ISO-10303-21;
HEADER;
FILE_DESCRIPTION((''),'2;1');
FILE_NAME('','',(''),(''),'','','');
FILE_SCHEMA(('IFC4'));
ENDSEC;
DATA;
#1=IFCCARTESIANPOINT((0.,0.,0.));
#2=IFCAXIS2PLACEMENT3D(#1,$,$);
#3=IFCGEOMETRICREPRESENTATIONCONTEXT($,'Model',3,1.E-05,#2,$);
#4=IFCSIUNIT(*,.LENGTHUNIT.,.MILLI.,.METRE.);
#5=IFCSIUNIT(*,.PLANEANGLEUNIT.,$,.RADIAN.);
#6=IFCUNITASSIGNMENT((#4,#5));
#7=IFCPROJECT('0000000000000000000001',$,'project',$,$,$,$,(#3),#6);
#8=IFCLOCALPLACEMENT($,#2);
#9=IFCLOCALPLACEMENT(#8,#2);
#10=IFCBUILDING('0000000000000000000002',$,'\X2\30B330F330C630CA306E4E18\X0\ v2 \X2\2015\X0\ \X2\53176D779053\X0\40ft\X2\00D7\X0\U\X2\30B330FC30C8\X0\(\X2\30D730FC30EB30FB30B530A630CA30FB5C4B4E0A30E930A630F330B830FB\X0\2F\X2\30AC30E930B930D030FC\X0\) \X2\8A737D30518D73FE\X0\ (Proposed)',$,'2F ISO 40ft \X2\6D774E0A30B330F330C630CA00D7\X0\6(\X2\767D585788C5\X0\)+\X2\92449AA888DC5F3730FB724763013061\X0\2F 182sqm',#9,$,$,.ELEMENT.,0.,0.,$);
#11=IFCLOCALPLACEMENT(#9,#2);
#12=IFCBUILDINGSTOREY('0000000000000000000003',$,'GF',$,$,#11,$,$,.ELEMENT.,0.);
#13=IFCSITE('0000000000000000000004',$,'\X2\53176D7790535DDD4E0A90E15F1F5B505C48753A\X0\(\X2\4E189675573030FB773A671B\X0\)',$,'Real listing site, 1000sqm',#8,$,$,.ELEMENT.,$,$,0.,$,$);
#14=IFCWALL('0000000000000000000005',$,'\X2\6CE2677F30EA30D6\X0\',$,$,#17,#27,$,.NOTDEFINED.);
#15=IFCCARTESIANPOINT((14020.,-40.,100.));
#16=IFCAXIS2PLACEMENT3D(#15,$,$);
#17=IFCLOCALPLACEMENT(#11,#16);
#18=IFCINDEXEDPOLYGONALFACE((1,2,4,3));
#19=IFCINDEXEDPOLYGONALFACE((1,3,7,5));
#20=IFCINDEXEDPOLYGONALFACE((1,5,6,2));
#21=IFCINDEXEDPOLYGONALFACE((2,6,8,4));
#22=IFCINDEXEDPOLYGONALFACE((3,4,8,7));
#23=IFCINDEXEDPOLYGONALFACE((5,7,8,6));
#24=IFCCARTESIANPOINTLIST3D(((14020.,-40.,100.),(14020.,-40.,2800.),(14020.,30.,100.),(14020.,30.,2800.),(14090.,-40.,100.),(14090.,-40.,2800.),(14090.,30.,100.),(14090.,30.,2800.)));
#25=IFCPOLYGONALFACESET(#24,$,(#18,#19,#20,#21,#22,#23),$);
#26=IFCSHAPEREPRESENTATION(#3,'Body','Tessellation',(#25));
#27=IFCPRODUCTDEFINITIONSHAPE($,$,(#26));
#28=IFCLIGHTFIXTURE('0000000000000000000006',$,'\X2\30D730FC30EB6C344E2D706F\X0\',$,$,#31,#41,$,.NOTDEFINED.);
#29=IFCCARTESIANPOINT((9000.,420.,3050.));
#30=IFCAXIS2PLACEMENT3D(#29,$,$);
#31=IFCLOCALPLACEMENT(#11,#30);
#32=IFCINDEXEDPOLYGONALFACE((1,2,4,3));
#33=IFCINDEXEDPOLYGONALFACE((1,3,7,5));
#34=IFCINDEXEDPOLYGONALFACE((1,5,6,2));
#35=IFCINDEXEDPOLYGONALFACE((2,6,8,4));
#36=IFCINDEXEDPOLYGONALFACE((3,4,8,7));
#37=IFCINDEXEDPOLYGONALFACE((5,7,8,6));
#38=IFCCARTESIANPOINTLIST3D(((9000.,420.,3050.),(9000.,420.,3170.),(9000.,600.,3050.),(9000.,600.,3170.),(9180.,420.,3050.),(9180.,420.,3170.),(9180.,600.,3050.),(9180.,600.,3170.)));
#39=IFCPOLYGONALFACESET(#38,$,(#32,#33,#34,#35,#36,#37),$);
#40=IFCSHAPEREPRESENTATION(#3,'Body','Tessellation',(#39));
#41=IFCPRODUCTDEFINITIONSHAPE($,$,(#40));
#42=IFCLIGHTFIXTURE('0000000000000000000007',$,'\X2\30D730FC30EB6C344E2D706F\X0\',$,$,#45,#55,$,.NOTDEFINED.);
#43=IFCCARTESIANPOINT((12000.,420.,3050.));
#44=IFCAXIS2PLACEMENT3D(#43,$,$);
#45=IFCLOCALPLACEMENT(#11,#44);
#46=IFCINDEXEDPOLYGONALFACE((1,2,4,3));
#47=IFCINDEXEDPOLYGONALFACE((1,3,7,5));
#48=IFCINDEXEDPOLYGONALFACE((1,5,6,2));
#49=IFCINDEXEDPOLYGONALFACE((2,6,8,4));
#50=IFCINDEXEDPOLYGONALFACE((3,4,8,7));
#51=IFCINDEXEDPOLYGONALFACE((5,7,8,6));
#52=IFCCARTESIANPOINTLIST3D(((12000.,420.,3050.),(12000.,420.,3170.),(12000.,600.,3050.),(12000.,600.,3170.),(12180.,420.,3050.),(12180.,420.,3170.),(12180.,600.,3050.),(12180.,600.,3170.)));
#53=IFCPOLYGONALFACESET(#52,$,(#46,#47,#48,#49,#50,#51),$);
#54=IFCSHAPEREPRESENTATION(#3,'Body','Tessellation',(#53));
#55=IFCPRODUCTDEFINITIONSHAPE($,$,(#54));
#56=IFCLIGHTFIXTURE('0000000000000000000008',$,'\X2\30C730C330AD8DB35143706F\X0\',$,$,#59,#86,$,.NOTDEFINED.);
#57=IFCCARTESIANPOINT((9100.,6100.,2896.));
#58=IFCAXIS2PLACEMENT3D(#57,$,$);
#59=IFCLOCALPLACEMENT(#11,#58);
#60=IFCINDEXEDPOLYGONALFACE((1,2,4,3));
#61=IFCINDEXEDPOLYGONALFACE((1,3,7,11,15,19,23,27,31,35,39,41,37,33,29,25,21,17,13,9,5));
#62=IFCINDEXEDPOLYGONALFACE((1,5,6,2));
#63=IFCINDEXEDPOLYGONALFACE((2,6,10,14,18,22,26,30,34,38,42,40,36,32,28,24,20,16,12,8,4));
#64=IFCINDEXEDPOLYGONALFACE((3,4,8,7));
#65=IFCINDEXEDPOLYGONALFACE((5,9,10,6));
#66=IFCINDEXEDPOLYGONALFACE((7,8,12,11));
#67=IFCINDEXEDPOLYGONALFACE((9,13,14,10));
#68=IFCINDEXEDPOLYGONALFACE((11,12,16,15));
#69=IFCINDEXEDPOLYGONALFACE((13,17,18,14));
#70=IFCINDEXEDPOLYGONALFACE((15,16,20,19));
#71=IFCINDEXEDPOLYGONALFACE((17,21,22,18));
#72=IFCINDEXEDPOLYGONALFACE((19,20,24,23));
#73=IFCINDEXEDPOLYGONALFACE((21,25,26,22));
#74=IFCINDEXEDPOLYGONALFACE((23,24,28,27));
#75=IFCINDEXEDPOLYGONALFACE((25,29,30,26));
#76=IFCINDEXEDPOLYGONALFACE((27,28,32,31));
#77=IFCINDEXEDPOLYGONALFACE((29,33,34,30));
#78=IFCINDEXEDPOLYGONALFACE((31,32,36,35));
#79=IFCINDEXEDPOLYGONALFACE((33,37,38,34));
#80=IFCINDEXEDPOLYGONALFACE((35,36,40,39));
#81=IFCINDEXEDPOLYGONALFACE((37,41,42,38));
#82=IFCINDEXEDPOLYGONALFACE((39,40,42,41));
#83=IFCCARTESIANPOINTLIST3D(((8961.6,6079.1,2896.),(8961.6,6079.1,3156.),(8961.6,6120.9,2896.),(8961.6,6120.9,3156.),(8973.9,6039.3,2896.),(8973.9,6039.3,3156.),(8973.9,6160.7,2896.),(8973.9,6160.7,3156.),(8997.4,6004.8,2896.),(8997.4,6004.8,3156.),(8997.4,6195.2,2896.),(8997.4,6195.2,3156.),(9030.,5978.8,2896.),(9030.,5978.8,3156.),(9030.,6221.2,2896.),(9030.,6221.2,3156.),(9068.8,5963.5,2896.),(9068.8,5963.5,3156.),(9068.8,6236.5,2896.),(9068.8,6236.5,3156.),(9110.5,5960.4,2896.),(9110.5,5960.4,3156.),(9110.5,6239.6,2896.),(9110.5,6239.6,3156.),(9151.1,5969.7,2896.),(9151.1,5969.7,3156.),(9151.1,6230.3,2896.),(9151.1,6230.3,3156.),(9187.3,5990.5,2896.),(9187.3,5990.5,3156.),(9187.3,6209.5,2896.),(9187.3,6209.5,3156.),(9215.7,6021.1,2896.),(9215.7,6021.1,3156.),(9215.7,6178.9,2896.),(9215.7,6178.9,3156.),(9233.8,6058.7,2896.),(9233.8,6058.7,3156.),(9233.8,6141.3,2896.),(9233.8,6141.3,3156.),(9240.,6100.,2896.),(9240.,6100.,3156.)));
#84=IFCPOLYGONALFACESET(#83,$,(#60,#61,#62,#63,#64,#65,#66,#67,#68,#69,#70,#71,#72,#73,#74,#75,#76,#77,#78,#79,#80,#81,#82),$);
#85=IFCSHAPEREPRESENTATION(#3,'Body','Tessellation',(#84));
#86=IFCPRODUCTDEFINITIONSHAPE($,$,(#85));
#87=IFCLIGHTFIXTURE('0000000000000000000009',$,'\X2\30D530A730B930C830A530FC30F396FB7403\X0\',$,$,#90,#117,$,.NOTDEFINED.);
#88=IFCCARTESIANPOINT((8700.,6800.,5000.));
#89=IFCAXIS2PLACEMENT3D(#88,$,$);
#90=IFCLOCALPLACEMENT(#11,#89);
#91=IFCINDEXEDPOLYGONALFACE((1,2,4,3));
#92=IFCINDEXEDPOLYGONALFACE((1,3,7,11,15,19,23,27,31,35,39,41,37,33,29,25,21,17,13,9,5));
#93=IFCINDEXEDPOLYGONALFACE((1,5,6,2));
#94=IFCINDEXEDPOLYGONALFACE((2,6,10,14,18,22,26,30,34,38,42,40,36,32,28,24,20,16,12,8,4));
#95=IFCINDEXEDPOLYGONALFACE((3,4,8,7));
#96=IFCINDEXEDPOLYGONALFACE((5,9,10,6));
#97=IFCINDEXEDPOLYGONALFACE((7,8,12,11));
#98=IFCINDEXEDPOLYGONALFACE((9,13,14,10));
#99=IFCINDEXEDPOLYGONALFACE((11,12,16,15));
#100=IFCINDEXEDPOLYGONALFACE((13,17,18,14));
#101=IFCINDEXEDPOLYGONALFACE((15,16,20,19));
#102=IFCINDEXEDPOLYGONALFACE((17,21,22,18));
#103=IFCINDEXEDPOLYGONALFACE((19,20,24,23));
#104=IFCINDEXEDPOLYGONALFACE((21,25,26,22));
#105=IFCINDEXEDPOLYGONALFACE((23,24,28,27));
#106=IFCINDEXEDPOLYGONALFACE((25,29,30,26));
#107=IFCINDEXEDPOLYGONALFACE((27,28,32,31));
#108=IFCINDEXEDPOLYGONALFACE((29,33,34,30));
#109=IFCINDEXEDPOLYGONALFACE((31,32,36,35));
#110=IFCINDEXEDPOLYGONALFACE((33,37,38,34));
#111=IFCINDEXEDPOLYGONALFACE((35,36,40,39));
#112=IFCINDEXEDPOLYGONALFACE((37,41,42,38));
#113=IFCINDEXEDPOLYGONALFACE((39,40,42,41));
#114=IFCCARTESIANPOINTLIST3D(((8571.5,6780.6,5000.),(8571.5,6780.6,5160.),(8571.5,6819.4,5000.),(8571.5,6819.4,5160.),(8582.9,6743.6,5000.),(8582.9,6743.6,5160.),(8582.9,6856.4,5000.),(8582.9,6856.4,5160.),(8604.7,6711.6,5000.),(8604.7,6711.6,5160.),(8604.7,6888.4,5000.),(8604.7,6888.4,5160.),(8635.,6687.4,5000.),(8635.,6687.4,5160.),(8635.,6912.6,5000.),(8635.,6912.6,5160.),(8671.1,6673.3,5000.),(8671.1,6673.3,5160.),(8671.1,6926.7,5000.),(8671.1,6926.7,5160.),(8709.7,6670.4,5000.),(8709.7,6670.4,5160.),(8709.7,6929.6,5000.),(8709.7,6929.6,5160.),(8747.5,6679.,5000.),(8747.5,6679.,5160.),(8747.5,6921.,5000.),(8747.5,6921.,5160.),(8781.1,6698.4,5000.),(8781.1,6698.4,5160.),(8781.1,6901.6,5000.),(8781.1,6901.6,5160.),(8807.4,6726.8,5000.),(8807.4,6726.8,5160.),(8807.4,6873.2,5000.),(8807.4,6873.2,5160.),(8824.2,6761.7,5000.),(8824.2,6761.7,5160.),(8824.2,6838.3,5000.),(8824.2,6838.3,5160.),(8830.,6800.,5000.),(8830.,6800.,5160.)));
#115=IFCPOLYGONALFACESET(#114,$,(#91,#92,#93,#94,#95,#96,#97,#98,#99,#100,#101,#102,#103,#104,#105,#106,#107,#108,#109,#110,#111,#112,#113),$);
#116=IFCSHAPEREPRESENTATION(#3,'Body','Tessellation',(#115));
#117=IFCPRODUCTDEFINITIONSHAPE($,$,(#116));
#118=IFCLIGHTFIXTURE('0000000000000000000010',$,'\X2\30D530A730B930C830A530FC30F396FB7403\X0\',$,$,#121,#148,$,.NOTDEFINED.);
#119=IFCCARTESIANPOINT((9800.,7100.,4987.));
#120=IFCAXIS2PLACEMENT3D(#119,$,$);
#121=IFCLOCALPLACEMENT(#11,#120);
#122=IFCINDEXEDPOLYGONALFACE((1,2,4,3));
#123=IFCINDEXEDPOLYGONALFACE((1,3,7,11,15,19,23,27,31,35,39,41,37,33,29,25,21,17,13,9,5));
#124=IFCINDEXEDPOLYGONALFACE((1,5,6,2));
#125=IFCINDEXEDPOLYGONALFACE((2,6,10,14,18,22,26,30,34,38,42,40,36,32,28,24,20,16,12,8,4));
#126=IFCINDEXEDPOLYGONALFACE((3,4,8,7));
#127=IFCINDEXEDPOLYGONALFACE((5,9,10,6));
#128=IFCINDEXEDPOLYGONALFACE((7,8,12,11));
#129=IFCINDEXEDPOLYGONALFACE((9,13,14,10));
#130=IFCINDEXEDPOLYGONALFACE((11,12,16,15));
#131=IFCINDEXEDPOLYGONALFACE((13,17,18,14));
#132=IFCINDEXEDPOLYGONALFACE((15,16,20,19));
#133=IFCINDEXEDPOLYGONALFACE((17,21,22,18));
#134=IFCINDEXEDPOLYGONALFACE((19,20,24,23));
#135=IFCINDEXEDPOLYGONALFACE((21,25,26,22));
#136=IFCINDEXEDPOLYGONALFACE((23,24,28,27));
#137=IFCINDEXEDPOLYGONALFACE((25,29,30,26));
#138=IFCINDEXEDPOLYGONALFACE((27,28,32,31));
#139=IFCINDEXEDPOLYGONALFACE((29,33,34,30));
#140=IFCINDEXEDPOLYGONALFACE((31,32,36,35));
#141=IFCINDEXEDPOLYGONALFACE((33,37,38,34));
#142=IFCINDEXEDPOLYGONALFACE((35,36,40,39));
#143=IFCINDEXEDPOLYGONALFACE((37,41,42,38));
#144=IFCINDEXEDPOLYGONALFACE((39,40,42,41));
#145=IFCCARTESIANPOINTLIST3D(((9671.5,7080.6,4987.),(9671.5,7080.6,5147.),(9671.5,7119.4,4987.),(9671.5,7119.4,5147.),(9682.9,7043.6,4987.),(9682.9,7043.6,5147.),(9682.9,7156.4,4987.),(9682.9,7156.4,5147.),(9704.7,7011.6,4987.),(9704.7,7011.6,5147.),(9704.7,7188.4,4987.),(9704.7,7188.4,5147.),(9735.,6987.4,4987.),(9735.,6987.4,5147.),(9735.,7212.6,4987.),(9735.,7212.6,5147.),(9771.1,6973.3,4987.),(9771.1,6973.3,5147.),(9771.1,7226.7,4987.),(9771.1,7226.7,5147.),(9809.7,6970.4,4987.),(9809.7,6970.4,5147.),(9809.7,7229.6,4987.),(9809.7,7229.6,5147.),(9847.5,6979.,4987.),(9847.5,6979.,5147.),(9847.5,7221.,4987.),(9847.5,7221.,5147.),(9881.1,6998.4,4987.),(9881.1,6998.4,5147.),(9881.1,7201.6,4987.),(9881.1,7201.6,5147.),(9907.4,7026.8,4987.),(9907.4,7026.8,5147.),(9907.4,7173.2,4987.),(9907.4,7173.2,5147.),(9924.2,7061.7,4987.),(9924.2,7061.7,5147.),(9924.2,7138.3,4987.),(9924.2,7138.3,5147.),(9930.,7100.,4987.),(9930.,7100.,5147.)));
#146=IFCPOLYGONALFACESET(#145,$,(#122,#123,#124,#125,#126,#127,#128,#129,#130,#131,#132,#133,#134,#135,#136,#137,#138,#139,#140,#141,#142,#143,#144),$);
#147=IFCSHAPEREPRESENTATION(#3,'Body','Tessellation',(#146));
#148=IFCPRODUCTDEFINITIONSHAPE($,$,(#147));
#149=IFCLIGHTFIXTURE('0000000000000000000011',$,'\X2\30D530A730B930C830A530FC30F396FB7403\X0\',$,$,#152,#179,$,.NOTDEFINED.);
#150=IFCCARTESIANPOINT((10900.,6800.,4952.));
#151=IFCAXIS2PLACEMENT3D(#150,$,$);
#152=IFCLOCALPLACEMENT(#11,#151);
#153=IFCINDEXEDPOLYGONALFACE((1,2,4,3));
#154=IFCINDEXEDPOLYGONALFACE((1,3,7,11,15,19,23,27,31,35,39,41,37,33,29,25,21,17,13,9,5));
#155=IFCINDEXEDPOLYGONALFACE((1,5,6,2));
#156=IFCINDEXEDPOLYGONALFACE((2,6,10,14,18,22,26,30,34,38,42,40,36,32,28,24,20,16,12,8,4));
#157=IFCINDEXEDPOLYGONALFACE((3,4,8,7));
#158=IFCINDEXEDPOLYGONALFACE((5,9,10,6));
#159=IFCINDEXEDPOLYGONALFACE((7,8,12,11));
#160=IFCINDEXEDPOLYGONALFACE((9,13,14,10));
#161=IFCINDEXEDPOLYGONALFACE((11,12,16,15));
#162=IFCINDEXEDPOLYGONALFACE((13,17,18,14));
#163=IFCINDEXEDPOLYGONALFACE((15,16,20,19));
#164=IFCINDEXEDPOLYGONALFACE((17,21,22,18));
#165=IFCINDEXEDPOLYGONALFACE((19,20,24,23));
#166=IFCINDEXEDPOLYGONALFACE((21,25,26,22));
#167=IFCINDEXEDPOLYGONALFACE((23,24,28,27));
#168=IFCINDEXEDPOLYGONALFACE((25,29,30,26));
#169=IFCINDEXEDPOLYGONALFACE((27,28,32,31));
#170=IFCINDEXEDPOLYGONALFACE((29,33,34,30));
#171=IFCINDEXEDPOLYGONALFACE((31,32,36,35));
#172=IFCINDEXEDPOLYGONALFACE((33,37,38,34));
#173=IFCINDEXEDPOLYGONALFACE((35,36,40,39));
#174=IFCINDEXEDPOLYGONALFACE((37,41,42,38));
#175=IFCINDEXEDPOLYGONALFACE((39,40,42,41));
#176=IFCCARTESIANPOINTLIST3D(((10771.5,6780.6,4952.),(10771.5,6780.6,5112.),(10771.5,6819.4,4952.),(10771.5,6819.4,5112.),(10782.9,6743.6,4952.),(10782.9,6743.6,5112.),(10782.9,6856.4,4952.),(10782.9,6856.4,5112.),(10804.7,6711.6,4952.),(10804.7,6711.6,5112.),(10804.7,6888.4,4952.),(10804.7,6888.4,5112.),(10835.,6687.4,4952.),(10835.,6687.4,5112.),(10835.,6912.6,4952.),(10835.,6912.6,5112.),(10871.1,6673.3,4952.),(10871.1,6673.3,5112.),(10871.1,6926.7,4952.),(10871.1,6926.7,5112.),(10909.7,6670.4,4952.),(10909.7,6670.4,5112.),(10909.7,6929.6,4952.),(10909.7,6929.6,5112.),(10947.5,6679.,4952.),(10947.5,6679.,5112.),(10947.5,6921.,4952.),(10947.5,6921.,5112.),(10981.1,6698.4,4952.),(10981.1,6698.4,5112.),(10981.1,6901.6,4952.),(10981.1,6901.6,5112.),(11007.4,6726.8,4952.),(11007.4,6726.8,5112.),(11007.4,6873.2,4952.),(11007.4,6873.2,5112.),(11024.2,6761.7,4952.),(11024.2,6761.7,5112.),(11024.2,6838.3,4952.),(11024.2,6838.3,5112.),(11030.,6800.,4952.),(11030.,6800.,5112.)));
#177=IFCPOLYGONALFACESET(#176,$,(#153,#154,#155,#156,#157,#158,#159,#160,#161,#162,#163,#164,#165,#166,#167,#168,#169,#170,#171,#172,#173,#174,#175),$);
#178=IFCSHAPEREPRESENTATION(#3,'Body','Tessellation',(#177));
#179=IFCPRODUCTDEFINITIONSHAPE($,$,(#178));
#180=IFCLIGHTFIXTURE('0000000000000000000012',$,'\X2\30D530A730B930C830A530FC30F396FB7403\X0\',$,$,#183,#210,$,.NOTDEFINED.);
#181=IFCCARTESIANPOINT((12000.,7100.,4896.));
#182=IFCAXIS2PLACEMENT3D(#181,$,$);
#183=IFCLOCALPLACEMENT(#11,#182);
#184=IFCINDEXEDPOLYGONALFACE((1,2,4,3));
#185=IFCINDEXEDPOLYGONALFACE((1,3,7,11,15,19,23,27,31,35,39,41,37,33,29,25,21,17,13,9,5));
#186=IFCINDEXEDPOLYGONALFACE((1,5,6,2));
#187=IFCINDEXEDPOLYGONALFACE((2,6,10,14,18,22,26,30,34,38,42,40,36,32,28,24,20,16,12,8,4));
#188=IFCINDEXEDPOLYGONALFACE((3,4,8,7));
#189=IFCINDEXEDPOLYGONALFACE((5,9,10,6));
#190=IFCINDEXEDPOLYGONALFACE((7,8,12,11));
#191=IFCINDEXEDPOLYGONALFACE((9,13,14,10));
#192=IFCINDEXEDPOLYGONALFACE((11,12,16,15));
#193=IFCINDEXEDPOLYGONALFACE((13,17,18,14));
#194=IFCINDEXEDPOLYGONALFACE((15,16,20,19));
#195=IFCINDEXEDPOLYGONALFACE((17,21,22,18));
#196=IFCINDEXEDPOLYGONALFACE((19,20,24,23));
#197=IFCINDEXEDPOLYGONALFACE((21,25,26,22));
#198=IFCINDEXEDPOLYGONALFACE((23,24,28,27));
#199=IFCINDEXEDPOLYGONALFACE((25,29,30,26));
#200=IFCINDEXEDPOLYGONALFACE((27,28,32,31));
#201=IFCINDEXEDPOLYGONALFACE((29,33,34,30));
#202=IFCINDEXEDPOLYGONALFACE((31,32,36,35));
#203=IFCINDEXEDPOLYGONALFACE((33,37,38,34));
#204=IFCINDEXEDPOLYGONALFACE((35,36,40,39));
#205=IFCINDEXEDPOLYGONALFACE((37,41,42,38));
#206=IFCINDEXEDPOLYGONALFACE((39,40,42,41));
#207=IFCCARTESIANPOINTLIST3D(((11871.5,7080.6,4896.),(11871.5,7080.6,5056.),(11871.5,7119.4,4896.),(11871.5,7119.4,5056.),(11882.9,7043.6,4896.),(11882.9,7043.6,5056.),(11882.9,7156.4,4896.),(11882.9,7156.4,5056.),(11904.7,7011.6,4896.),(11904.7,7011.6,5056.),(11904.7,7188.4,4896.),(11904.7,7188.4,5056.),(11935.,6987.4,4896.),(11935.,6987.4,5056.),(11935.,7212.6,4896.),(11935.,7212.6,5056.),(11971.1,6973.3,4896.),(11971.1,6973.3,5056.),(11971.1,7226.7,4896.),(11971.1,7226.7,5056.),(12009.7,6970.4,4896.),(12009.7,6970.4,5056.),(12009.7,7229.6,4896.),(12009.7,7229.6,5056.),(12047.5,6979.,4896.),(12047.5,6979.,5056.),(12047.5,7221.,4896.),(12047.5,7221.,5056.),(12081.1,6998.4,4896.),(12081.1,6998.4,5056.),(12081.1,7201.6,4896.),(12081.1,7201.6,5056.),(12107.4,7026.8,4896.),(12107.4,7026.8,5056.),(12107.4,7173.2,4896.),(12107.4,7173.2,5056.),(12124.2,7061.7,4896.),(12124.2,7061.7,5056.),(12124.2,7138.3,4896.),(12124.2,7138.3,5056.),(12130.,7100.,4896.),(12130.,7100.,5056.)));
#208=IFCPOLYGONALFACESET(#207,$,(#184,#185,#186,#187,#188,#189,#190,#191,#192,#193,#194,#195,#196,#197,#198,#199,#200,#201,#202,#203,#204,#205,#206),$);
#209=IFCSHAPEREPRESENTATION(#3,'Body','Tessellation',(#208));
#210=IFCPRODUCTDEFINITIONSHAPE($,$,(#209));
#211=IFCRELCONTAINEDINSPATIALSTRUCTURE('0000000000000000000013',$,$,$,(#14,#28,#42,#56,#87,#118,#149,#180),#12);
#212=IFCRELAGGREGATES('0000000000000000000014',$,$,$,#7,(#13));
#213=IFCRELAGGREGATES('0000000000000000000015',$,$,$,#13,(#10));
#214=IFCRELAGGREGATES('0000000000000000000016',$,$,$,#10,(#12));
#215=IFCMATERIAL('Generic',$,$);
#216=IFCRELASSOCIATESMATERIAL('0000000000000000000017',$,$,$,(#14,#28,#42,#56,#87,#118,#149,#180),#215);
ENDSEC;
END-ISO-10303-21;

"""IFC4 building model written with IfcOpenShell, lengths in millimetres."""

from ifc_helpers import new_model, si_unit, frame, frame_2d, origin, origin_2d, place, context, project, spatial, rectangle, circle, extrude, material, element, save


model = new_model("IFC4")

# Units and contexts
model_context = context("Model", 3, precision=1e-05, world=origin())
ifc_project = project(units=[si_unit("LENGTHUNIT", "METRE", prefix="MILLI"), si_unit("PLANEANGLEUNIT", "RADIAN")], contexts=[model_context])

# Site, building, storey
site_placement = place(None, origin())
site = spatial("IfcSite", under=ifc_project, at=site_placement, Name="北海道川上郡弟子屈町(丘陵地・眺望)", ObjectType="Real listing site, 1000sqm", CompositionType="ELEMENT", RefElevation=0.0)
building_placement = place(site_placement, origin())
building = spatial("IfcBuilding", under=site, at=building_placement, Name="コンテナの丘 v2 ― 北海道40ft×Uコート(プール・サウナ・屋上ラウンジ・2Fガラスバー) 詳細再現 (Proposed)", ObjectType="2F ISO 40ft 海上コンテナ×6(白塗装)+鉄骨補強・片持ち2F 182sqm", CompositionType="ELEMENT", ElevationOfRefHeight=0.0, ElevationOfTerrain=0.0)
storey_placement = place(building_placement, origin())
storey = spatial("IfcBuildingStorey", under=building, at=storey_placement, Name="GF", CompositionType="ELEMENT", Elevation=0.0)

# Shared definitions
ifc_material = material(Name="Generic")

# Wall
wall_1_placement = place(storey_placement, frame((14020.0, -40.0, 100.0)))
element("IfcWall", 1, at=wall_1_placement, inside=storey, material=ifc_material, Name="波板リブ", PredefinedType="NOTDEFINED", context=model_context, shape_type="SweptSolid", body=[
    extrude(rectangle(XDim=70.0, YDim=70.0, at=frame_2d((35.0, 35.0))), frame((14020.0, -40.0, 100.0)), (0.0, 0.0, 1.0), 2700.0),
])

# Light fixtures
light_fixture_1_placement = place(storey_placement, frame((9000.0, 420.0, 3050.0)))
element("IfcLightFixture", 2, at=light_fixture_1_placement, inside=storey, material=ifc_material, Name="プール水中灯", PredefinedType="NOTDEFINED", context=model_context, shape_type="SweptSolid", body=[
    extrude(rectangle(XDim=180.0, YDim=180.0, at=frame_2d((90.0, 90.0))), frame((9000.0, 420.0, 3050.0)), (0.0, 0.0, 1.0), 120.0),
])
light_fixture_2_placement = place(storey_placement, frame((12000.0, 420.0, 3050.0)))
element("IfcLightFixture", 3, at=light_fixture_2_placement, inside=storey, material=ifc_material, Name="プール水中灯", PredefinedType="NOTDEFINED", context=model_context, shape_type="SweptSolid", body=[
    extrude(rectangle(XDim=180.0, YDim=180.0, at=frame_2d((90.0, 90.0))), frame((12000.0, 420.0, 3050.0)), (0.0, 0.0, 1.0), 120.0),
])
light_fixture_3_placement = place(storey_placement, frame((9100.0, 6100.0, 2896.0)))
element("IfcLightFixture", 4, at=light_fixture_3_placement, inside=storey, material=ifc_material, Name="デッキ足元灯", PredefinedType="NOTDEFINED", context=model_context, shape_type="SweptSolid", body=[
    extrude(circle(Radius=140.0, at=origin_2d()), frame((9100.0, 6100.0, 2896.0)), (0.0, 0.0, 1.0), 260.0),
])
light_fixture_4_placement = place(storey_placement, frame((8700.0, 6800.0, 5000.0)))
element("IfcLightFixture", 5, at=light_fixture_4_placement, inside=storey, material=ifc_material, Name="フェストゥーン電球", PredefinedType="NOTDEFINED", context=model_context, shape_type="SweptSolid", body=[
    extrude(circle(Radius=130.0, at=origin_2d()), frame((8700.0, 6800.0, 5000.0)), (0.0, 0.0, 1.0), 160.0),
])
light_fixture_5_placement = place(storey_placement, frame((9800.0, 7100.0, 4987.0)))
element("IfcLightFixture", 6, at=light_fixture_5_placement, inside=storey, material=ifc_material, Name="フェストゥーン電球", PredefinedType="NOTDEFINED", context=model_context, shape_type="SweptSolid", body=[
    extrude(circle(Radius=130.0, at=origin_2d()), frame((9800.0, 7100.0, 4987.0)), (0.0, 0.0, 1.0), 160.0),
])
light_fixture_6_placement = place(storey_placement, frame((10900.0, 6800.0, 4952.0)))
element("IfcLightFixture", 7, at=light_fixture_6_placement, inside=storey, material=ifc_material, Name="フェストゥーン電球", PredefinedType="NOTDEFINED", context=model_context, shape_type="SweptSolid", body=[
    extrude(circle(Radius=130.0, at=origin_2d()), frame((10900.0, 6800.0, 4952.0)), (0.0, 0.0, 1.0), 160.0),
])
light_fixture_7_placement = place(storey_placement, frame((12000.0, 7100.0, 4896.0)))
element("IfcLightFixture", 8, at=light_fixture_7_placement, inside=storey, material=ifc_material, Name="フェストゥーン電球", PredefinedType="NOTDEFINED", context=model_context, shape_type="SweptSolid", body=[
    extrude(circle(Radius=130.0, at=origin_2d()), frame((12000.0, 7100.0, 4896.0)), (0.0, 0.0, 1.0), 160.0),
])

save(model, "model.ifc")
